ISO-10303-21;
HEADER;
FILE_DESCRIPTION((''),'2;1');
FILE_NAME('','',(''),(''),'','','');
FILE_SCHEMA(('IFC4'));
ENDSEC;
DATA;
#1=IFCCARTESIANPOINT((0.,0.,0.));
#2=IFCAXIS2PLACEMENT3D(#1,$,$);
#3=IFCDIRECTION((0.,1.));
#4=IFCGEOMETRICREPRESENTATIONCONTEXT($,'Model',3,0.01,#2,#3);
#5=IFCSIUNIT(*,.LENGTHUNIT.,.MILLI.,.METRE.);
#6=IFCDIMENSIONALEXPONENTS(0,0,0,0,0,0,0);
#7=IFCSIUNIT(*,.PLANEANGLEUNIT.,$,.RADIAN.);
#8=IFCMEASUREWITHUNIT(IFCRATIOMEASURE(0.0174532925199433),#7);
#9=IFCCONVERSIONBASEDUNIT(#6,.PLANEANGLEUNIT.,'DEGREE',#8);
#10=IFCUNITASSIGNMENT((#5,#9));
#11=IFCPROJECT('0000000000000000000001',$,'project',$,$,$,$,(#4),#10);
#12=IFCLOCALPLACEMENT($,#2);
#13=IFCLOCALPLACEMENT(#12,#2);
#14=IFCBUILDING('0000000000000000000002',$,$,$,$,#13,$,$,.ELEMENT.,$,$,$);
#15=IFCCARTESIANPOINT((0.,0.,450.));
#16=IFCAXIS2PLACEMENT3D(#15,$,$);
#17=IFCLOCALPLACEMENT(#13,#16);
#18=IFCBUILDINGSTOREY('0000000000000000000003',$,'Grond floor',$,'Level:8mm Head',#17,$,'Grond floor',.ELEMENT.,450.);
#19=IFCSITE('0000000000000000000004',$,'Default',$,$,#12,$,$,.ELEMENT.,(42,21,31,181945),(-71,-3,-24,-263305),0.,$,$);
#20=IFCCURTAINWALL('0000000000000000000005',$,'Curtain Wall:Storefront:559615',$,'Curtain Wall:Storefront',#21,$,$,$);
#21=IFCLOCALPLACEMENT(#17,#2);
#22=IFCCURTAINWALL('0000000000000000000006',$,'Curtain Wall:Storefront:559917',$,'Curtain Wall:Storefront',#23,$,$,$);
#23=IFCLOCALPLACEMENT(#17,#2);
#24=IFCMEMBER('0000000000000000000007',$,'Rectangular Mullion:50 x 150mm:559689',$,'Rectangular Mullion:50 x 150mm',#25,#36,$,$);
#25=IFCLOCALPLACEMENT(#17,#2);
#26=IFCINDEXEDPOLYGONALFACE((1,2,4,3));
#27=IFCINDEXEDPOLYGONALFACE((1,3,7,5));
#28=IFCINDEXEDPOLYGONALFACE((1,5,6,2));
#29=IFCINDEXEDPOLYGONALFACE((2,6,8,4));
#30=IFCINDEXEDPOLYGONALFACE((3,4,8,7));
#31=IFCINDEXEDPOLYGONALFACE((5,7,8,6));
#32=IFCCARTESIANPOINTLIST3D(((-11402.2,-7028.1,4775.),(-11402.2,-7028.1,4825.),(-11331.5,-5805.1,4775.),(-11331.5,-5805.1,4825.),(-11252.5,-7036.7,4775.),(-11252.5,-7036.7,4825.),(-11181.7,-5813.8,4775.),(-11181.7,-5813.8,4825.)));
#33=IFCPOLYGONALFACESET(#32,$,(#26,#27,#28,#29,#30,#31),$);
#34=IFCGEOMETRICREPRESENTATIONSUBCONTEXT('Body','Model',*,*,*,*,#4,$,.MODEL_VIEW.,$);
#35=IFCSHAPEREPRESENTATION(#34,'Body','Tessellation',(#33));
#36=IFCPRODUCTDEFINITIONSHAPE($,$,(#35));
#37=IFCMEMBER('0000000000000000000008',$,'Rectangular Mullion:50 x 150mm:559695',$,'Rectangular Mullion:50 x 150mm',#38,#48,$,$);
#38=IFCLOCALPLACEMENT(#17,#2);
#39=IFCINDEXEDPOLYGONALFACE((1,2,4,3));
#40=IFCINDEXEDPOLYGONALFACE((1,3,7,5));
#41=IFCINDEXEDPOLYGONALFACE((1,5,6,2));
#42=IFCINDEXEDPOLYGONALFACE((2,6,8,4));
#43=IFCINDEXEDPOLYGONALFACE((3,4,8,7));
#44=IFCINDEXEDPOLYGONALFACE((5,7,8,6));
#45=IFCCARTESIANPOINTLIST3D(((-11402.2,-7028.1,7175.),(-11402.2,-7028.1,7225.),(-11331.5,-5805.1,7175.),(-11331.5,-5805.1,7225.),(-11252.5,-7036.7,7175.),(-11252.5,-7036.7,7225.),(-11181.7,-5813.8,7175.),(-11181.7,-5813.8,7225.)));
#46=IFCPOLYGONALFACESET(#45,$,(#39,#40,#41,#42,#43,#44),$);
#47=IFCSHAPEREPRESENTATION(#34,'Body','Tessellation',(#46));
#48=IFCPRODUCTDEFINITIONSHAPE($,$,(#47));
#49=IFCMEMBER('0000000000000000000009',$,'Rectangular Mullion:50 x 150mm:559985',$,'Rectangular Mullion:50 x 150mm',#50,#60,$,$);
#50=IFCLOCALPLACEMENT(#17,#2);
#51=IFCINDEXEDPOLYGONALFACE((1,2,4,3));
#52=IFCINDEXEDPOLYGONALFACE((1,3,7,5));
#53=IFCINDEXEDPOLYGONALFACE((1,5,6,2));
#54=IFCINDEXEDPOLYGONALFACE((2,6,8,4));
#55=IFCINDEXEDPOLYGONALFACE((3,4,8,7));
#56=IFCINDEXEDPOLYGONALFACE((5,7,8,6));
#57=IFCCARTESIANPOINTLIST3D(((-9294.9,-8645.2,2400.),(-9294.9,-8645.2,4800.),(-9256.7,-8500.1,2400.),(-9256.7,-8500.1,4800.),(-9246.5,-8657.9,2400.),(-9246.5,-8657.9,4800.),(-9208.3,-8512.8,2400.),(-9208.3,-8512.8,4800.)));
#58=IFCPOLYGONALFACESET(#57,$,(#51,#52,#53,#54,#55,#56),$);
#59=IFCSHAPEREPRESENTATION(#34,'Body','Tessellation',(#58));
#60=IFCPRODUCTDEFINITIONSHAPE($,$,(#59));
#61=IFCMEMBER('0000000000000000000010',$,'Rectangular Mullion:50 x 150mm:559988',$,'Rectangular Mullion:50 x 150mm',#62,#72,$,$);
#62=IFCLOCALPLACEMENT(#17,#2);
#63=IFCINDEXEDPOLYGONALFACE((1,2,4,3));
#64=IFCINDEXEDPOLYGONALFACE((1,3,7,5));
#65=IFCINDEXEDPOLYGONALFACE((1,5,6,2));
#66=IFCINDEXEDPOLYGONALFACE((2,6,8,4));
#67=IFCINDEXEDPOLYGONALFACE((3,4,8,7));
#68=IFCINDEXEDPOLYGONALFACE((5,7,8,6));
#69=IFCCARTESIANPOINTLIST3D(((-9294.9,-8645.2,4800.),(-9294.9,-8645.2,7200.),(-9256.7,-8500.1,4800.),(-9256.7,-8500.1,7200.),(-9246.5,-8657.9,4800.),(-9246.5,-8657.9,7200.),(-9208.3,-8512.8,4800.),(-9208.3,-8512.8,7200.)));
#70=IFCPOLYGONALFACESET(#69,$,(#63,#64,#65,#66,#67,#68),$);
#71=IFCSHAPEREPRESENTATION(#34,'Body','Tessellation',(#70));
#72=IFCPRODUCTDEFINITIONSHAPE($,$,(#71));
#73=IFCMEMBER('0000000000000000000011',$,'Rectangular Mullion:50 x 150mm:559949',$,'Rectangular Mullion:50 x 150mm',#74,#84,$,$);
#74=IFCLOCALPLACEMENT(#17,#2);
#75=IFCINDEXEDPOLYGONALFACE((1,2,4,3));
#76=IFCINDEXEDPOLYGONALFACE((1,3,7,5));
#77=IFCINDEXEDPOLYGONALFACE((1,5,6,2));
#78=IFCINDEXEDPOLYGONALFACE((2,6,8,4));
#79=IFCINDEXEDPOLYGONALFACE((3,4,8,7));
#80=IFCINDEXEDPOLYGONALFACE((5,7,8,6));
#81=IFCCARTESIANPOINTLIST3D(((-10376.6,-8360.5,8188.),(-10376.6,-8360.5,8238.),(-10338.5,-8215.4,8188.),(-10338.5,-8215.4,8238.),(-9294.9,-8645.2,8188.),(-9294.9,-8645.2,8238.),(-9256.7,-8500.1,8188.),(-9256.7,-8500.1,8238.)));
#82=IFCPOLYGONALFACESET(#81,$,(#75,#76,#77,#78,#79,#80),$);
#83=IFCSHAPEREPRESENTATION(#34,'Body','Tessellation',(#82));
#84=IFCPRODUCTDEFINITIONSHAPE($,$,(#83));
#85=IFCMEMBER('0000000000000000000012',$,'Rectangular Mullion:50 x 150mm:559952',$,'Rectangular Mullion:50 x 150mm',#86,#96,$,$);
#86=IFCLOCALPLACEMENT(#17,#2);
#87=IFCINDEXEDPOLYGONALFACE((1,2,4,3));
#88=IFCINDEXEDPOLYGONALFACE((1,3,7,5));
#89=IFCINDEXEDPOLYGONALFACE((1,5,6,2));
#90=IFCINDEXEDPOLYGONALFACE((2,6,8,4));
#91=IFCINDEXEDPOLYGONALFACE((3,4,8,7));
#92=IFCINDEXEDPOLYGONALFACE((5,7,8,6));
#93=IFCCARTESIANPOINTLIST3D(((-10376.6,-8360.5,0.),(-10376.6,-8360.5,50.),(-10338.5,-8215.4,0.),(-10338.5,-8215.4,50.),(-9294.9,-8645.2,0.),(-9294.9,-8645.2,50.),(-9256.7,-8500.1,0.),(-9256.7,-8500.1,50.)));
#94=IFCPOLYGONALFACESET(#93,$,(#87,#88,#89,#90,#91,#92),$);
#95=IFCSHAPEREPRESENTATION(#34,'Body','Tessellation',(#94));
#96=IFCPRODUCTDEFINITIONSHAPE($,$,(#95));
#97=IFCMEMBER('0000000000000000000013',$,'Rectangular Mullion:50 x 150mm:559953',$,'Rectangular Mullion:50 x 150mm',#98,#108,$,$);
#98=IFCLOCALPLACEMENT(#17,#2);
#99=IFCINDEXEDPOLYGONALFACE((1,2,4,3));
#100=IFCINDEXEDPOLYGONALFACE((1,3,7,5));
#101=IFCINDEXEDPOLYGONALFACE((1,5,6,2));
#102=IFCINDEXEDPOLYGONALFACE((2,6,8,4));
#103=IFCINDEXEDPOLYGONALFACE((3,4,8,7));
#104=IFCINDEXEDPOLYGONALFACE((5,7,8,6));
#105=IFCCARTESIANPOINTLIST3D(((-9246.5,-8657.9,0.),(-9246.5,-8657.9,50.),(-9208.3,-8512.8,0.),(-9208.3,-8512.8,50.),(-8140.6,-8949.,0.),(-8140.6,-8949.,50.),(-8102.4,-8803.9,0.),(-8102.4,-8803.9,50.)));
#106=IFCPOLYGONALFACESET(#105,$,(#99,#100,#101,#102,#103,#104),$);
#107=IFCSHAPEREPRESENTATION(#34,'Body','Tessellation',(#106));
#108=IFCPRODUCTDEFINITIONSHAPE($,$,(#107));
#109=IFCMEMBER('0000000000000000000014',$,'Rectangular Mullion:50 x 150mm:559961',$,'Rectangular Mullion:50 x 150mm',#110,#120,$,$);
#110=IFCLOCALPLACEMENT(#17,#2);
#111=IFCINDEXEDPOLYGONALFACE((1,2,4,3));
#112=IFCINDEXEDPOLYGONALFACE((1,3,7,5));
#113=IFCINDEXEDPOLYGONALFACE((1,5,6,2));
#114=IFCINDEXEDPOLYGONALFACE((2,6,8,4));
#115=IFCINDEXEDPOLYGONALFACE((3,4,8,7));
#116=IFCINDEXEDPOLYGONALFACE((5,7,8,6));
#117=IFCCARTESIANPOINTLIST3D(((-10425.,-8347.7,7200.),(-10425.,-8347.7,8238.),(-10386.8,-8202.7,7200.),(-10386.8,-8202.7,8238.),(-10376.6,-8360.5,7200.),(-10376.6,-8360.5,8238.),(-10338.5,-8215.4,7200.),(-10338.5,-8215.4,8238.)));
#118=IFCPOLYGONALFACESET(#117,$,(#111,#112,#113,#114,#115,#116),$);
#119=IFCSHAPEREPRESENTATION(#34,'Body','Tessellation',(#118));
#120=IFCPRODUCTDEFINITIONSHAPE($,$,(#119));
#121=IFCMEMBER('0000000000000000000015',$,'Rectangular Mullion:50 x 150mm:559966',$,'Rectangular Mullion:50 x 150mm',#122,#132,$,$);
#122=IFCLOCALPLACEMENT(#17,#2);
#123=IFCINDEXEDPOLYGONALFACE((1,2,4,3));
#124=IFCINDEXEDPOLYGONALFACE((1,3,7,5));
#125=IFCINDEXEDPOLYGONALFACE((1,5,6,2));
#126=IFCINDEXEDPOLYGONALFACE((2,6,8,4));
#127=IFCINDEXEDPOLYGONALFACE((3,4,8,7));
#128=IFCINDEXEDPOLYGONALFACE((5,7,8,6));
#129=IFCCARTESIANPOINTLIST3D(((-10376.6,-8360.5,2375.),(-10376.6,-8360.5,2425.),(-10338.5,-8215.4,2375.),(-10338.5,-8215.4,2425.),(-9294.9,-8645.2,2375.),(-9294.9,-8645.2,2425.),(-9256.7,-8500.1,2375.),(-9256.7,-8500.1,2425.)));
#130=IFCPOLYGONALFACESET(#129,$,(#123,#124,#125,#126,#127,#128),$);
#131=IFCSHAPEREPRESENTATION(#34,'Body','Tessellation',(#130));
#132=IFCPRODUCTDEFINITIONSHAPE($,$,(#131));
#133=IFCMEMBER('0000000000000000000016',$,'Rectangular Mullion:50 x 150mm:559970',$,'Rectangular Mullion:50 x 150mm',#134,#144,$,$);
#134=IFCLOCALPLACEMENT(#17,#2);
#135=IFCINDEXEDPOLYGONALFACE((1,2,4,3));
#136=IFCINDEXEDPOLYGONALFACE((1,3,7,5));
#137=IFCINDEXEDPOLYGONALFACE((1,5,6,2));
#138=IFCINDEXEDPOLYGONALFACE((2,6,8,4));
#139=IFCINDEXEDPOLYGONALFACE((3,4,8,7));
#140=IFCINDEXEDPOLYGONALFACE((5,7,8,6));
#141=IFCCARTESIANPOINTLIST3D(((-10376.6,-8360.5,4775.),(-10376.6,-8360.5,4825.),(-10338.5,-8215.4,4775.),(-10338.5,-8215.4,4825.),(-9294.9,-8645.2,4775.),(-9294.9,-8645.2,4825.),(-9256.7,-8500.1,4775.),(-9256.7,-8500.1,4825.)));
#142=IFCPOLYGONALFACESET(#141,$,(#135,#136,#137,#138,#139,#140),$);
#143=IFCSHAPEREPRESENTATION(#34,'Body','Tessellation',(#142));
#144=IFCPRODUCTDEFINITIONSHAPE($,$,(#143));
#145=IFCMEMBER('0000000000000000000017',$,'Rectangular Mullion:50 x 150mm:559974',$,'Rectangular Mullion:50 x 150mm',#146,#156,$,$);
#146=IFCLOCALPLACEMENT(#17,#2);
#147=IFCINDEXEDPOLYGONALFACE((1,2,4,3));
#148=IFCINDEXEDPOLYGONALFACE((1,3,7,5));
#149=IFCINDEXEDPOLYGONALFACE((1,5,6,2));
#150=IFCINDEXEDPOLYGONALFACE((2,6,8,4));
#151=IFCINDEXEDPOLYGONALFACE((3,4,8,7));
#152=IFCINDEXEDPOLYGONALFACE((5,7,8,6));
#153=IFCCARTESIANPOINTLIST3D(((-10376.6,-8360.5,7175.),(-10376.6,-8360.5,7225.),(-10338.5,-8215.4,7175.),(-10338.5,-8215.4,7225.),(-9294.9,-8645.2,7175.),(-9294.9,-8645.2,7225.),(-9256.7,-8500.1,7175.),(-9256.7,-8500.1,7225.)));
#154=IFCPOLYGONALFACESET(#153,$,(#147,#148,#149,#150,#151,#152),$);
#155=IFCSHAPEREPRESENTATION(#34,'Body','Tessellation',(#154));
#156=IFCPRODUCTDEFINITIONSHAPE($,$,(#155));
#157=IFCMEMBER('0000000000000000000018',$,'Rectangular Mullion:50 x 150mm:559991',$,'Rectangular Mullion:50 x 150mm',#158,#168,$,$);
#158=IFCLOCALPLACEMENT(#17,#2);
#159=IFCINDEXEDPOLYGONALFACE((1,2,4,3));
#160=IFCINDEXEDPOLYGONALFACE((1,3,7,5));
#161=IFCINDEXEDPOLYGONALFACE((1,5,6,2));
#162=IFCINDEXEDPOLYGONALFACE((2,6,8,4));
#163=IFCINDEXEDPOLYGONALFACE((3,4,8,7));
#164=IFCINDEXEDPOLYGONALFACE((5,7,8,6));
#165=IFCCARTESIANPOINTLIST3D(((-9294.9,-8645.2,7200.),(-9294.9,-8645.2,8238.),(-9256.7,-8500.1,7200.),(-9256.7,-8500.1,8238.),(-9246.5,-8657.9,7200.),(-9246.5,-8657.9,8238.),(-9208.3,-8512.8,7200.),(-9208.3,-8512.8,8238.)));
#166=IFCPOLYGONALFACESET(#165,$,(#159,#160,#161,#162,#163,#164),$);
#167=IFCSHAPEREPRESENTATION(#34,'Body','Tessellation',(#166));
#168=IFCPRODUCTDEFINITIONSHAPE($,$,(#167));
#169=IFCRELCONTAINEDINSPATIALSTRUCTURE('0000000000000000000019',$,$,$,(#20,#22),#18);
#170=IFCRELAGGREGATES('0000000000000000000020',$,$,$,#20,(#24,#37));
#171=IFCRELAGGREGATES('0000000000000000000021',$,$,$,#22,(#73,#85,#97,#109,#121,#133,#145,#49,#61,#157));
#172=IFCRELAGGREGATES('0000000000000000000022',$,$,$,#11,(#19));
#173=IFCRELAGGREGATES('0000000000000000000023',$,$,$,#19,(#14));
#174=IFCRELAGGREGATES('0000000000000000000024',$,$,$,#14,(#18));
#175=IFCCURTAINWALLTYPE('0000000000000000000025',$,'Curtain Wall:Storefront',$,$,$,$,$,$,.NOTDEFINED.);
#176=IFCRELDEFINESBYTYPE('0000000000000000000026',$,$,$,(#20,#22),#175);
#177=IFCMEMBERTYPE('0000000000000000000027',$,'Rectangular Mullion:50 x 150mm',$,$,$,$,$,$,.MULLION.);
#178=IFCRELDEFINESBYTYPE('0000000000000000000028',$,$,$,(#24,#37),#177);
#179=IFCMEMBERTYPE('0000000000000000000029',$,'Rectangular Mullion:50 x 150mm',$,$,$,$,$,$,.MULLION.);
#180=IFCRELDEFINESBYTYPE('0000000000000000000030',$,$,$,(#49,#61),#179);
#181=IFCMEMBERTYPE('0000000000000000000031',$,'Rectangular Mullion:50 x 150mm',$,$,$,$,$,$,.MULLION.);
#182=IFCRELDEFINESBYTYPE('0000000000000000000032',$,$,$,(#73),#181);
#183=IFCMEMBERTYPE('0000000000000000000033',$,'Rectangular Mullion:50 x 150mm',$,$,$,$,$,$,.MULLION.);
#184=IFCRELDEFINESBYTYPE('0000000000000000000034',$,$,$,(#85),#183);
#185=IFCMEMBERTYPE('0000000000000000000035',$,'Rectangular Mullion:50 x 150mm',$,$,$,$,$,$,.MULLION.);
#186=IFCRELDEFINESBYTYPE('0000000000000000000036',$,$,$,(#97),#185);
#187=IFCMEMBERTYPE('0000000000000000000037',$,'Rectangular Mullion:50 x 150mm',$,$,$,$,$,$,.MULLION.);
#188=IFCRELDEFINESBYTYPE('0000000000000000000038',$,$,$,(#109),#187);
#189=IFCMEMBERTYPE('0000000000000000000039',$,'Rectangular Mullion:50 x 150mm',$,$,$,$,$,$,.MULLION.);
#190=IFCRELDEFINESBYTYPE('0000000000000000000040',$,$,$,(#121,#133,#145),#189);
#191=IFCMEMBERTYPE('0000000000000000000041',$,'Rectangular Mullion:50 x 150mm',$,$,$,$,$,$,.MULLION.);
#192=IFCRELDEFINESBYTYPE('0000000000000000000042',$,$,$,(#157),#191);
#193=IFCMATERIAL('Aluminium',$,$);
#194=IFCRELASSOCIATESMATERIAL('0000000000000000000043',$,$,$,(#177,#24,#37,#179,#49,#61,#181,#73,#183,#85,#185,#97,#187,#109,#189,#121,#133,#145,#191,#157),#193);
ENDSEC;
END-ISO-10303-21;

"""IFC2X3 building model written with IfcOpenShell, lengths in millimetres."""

from ifc_helpers import new_model, entity, si_unit, converted_unit, direction, frame, frame_2d, origin, origin_2d_with_axis, place, context, subcontext, project, spatial, rectangle, extrude, source, transform, mapped, material, type_object, type_shapes, element, aggregate, save


model = new_model("IFC2X3")

# Units and contexts
model_context = context("Model", 3, precision=0.01, world=origin(), true_north=direction((0.0, 1.0)))
body_context = subcontext(model_context, "Body", "Model", "MODEL_VIEW")
ifc_project = project(units=[si_unit("LENGTHUNIT", "METRE", prefix="MILLI"), converted_unit("PLANEANGLEUNIT", "DEGREE", entity("IfcRatioMeasure", 0.0174532925199433), si_unit("PLANEANGLEUNIT", "RADIAN"), dimensions=[0, 0, 0, 0, 0, 0, 0])], contexts=[model_context])

# Site, building, storey
site_placement = place(None, origin())
site = spatial("IfcSite", under=ifc_project, at=site_placement, Name="Default", CompositionType="ELEMENT", RefLatitude=(42, 21, 31, 181945), RefLongitude=(-71, -3, -24, -263305), RefElevation=0.0)
building_placement = place(site_placement, origin())
building = spatial("IfcBuilding", under=site, at=building_placement, CompositionType="ELEMENT")
storey_placement = place(building_placement, frame((0.0, 0.0, 450.0)))
storey = spatial("IfcBuildingStorey", under=building, at=storey_placement, Name="Grond floor", ObjectType="Level:8mm Head", LongName="Grond floor", CompositionType="ELEMENT", Elevation=450.0)

# Curtain walls
curtain_wall_type = type_object("IfcCurtainWallType", Name="Curtain Wall:Storefront", PredefinedType="NOTDEFINED")
curtain_wall_1_placement = place(storey_placement, frame((0.0, 0.0, -450.0)))
curtain_wall_1 = element("IfcCurtainWall", 1, at=curtain_wall_1_placement, inside=storey, type_object=curtain_wall_type, Name="Curtain Wall:Storefront:559615", ObjectType="Curtain Wall:Storefront")
ifc_material_1 = material(Name="Aluminium")
curtain_wall_2_placement = place(storey_placement, frame((0.0, 0.0, -450.0)))
curtain_wall_2 = element("IfcCurtainWall", 2, at=curtain_wall_2_placement, inside=storey, type_object=curtain_wall_type, Name="Curtain Wall:Storefront:559917", ObjectType="Curtain Wall:Storefront")

# Members
member_type_1 = type_object("IfcMemberType", Name="Rectangular Mullion:50 x 150mm", PredefinedType="MULLION", material=ifc_material_1)
shared_shape_1 = source(origin(), body_context, "Body", "SweptSolid", [
    extrude(rectangle(XDim=150.0, YDim=50.0, at=origin_2d_with_axis()), frame((0.0, 0.0, -1225.0), z_axis=(0.0, 0.0, 1.0), x_axis=(0.0, -1.0, 0.0)), (0.0, 0.0, 1.0), 1225.0),
])
type_shapes(member_type_1, [shared_shape_1])
member_1_placement = place(storey_placement, frame((-11327.4, -7032.4, 4800.0), z_axis=(-0.057751, -0.998331, 0.0), x_axis=(0.0, 0.0, 1.0)))
member_1 = element("IfcMember", 3, at=member_1_placement, type_object=member_type_1, material=ifc_material_1, Name="Rectangular Mullion:50 x 150mm:559689", ObjectType="Rectangular Mullion:50 x 150mm", context=body_context, shape_type="MappedRepresentation", body=[
    mapped(shared_shape_1, transform((0.0, 0.0, 0.0), scale=1.0)),
])
member_2_placement = place(storey_placement, frame((-11327.4, -7032.4, 7200.0), z_axis=(-0.057751, -0.998331, 0.0), x_axis=(0.0, 0.0, 1.0)))
member_2 = element("IfcMember", 4, at=member_2_placement, type_object=member_type_1, material=ifc_material_1, Name="Rectangular Mullion:50 x 150mm:559695", ObjectType="Rectangular Mullion:50 x 150mm", context=body_context, shape_type="MappedRepresentation", body=[
    mapped(shared_shape_1, transform((0.0, 0.0, 0.0), scale=1.0)),
])
member_type_2 = type_object("IfcMemberType", Name="Rectangular Mullion:50 x 150mm", PredefinedType="MULLION", material=ifc_material_1)
shared_shape_2 = source(origin(), body_context, "Body", "SweptSolid", [
    extrude(rectangle(XDim=150.0, YDim=50.0, at=origin_2d_with_axis()), frame((0.0, 0.0, -2400.0), z_axis=(0.0, 0.0, 1.0), x_axis=(0.0, -1.0, 0.0)), (0.0, 0.0, 1.0), 2400.0),
])
type_shapes(member_type_2, [shared_shape_2])
member_3_placement = place(storey_placement, frame((-9251.6, -8579.0, 2400.0), z_axis=(0.0, 0.0, -1.0), x_axis=(0.967067, -0.25452, 0.0)))
member_3 = element("IfcMember", 5, at=member_3_placement, type_object=member_type_2, material=ifc_material_1, Name="Rectangular Mullion:50 x 150mm:559985", ObjectType="Rectangular Mullion:50 x 150mm", context=body_context, shape_type="MappedRepresentation", body=[
    mapped(shared_shape_2, transform((0.0, 0.0, 0.0), scale=1.0)),
])
member_4_placement = place(storey_placement, frame((-9251.6, -8579.0, 4800.0), z_axis=(0.0, 0.0, -1.0), x_axis=(0.967067, -0.25452, 0.0)))
member_4 = element("IfcMember", 6, at=member_4_placement, type_object=member_type_2, material=ifc_material_1, Name="Rectangular Mullion:50 x 150mm:559988", ObjectType="Rectangular Mullion:50 x 150mm", context=body_context, shape_type="MappedRepresentation", body=[
    mapped(shared_shape_2, transform((0.0, 0.0, 0.0), scale=1.0)),
])
member_type_3 = type_object("IfcMemberType", Name="Rectangular Mullion:50 x 150mm", PredefinedType="MULLION", material=ifc_material_1)
shared_shape_3 = source(origin(), body_context, "Body", "SweptSolid", [
    extrude(rectangle(XDim=150.0, YDim=50.0, at=origin_2d_with_axis()), frame((-25.0, 0.0, -1118.6), z_axis=(0.0, 0.0, 1.0), x_axis=(0.0, -1.0, 0.0)), (0.0, 0.0, 1.0), 1118.6),
])
type_shapes(member_type_3, [shared_shape_3])
member_5_placement = place(storey_placement, frame((-9275.8, -8572.6, 8238.0), z_axis=(0.967067, -0.25452, 0.0), x_axis=(0.0, 0.0, 1.0)))
member_5 = element("IfcMember", 7, at=member_5_placement, type_object=member_type_3, material=ifc_material_1, Name="Rectangular Mullion:50 x 150mm:559949", ObjectType="Rectangular Mullion:50 x 150mm", context=body_context, shape_type="MappedRepresentation", body=[
    mapped(shared_shape_3, transform((0.0, 0.0, 0.0), scale=1.0)),
])
member_type_4 = type_object("IfcMemberType", Name="Rectangular Mullion:50 x 150mm", PredefinedType="MULLION", material=ifc_material_1)
shared_shape_4 = source(origin(), body_context, "Body", "SweptSolid", [
    extrude(rectangle(XDim=150.0, YDim=50.0, at=origin_2d_with_axis()), frame((-25.0, 0.0, -1118.6), z_axis=(0.0, 0.0, 1.0), x_axis=(0.0, -1.0, 0.0)), (0.0, 0.0, 1.0), 1118.6),
])
type_shapes(member_type_4, [shared_shape_4])
member_6_placement = place(storey_placement, frame((-10357.5, -8287.9, 0.0), z_axis=(-0.967067, 0.25452, 0.0), x_axis=(0.0, 0.0, -1.0)))
member_6 = element("IfcMember", 8, at=member_6_placement, type_object=member_type_4, material=ifc_material_1, Name="Rectangular Mullion:50 x 150mm:559952", ObjectType="Rectangular Mullion:50 x 150mm", context=body_context, shape_type="MappedRepresentation", body=[
    mapped(shared_shape_4, transform((0.0, 0.0, 0.0), scale=1.0)),
])
member_type_5 = type_object("IfcMemberType", Name="Rectangular Mullion:50 x 150mm", PredefinedType="MULLION", material=ifc_material_1)
shared_shape_5 = source(origin(), body_context, "Body", "SweptSolid", [
    extrude(rectangle(XDim=150.0, YDim=50.0, at=frame_2d((0.0, 0.0), x_axis=(1.0, 0.0))), frame((-25.0, 0.0, -1143.6), z_axis=(0.0, 0.0, 1.0), x_axis=(0.0, -1.0, 0.0)), (0.0, 0.0, 1.0), 1143.6),
])
type_shapes(member_type_5, [shared_shape_5])
member_7_placement = place(storey_placement, frame((-9227.4, -8585.4, 0.0), z_axis=(-0.967067, 0.25452, 0.0), x_axis=(0.0, 0.0, -1.0)))
member_7 = element("IfcMember", 9, at=member_7_placement, type_object=member_type_5, material=ifc_material_1, Name="Rectangular Mullion:50 x 150mm:559953", ObjectType="Rectangular Mullion:50 x 150mm", context=body_context, shape_type="MappedRepresentation", body=[
    mapped(shared_shape_5, transform((0.0, 0.0, 0.0), scale=1.0)),
])
member_type_6 = type_object("IfcMemberType", Name="Rectangular Mullion:50 x 150mm", PredefinedType="MULLION", material=ifc_material_1)
shared_shape_6 = source(origin(), body_context, "Body", "SweptSolid", [
    extrude(rectangle(XDim=150.0, YDim=50.0, at=origin_2d_with_axis()), frame((-25.0, 0.0, -1038.0), z_axis=(0.0, 0.0, 1.0), x_axis=(0.0, -1.0, 0.0)), (0.0, 0.0, 1.0), 1038.0),
])
type_shapes(member_type_6, [shared_shape_6])
member_8_placement = place(storey_placement, frame((-10405.9, -8275.2, 8238.0), z_axis=(0.0, 0.0, 1.0), x_axis=(-0.967067, 0.25452, 0.0)))
member_8 = element("IfcMember", 10, at=member_8_placement, type_object=member_type_6, material=ifc_material_1, Name="Rectangular Mullion:50 x 150mm:559961", ObjectType="Rectangular Mullion:50 x 150mm", context=body_context, shape_type="MappedRepresentation", body=[
    mapped(shared_shape_6, transform((0.0, 0.0, 0.0), scale=1.0)),
])
member_type_7 = type_object("IfcMemberType", Name="Rectangular Mullion:50 x 150mm", PredefinedType="MULLION", material=ifc_material_1)
shared_shape_7 = source(origin(), body_context, "Body", "SweptSolid", [
    extrude(rectangle(XDim=150.0, YDim=50.0, at=origin_2d_with_axis()), frame((0.0, 0.0, -1118.6), z_axis=(0.0, 0.0, 1.0), x_axis=(0.0, -1.0, 0.0)), (0.0, 0.0, 1.0), 1118.6),
])
type_shapes(member_type_7, [shared_shape_7])
member_9_placement = place(storey_placement, frame((-9275.8, -8572.6, 2400.0), z_axis=(0.967067, -0.25452, 0.0), x_axis=(0.0, 0.0, 1.0)))
member_9 = element("IfcMember", 11, at=member_9_placement, type_object=member_type_7, material=ifc_material_1, Name="Rectangular Mullion:50 x 150mm:559966", ObjectType="Rectangular Mullion:50 x 150mm", context=body_context, shape_type="MappedRepresentation", body=[
    mapped(shared_shape_7, transform((0.0, 0.0, 0.0), scale=1.0)),
])
member_10_placement = place(storey_placement, frame((-9275.8, -8572.6, 4800.0), z_axis=(0.967067, -0.25452, 0.0), x_axis=(0.0, 0.0, 1.0)))
member_10 = element("IfcMember", 12, at=member_10_placement, type_object=member_type_7, material=ifc_material_1, Name="Rectangular Mullion:50 x 150mm:559970", ObjectType="Rectangular Mullion:50 x 150mm", context=body_context, shape_type="MappedRepresentation", body=[
    mapped(shared_shape_7, transform((0.0, 0.0, 0.0), scale=1.0)),
])
member_11_placement = place(storey_placement, frame((-9275.8, -8572.6, 7200.0), z_axis=(0.967067, -0.25452, 0.0), x_axis=(0.0, 0.0, 1.0)))
member_11 = element("IfcMember", 13, at=member_11_placement, type_object=member_type_7, material=ifc_material_1, Name="Rectangular Mullion:50 x 150mm:559974", ObjectType="Rectangular Mullion:50 x 150mm", context=body_context, shape_type="MappedRepresentation", body=[
    mapped(shared_shape_7, transform((0.0, 0.0, 0.0), scale=1.0)),
])
member_type_8 = type_object("IfcMemberType", Name="Rectangular Mullion:50 x 150mm", PredefinedType="MULLION", material=ifc_material_1)
shared_shape_8 = source(origin(), body_context, "Body", "SweptSolid", [
    extrude(rectangle(XDim=150.0, YDim=50.0, at=origin_2d_with_axis()), frame((0.0, 0.0, -1038.0), z_axis=(0.0, 0.0, 1.0), x_axis=(0.0, -1.0, 0.0)), (0.0, 0.0, 1.0), 1038.0),
])
type_shapes(member_type_8, [shared_shape_8])
member_12_placement = place(storey_placement, frame((-9251.6, -8579.0, 7200.0), z_axis=(0.0, 0.0, -1.0), x_axis=(0.967067, -0.25452, 0.0)))
member_12 = element("IfcMember", 14, at=member_12_placement, type_object=member_type_8, material=ifc_material_1, Name="Rectangular Mullion:50 x 150mm:559991", ObjectType="Rectangular Mullion:50 x 150mm", context=body_context, shape_type="MappedRepresentation", body=[
    mapped(shared_shape_8, transform((0.0, 0.0, 0.0), scale=1.0)),
])

aggregate(curtain_wall_1, [member_1, member_2])
aggregate(curtain_wall_2, [member_5, member_6, member_7, member_8, member_9, member_10, member_11, member_3, member_4, member_12])

save(model, "model.ifc")
